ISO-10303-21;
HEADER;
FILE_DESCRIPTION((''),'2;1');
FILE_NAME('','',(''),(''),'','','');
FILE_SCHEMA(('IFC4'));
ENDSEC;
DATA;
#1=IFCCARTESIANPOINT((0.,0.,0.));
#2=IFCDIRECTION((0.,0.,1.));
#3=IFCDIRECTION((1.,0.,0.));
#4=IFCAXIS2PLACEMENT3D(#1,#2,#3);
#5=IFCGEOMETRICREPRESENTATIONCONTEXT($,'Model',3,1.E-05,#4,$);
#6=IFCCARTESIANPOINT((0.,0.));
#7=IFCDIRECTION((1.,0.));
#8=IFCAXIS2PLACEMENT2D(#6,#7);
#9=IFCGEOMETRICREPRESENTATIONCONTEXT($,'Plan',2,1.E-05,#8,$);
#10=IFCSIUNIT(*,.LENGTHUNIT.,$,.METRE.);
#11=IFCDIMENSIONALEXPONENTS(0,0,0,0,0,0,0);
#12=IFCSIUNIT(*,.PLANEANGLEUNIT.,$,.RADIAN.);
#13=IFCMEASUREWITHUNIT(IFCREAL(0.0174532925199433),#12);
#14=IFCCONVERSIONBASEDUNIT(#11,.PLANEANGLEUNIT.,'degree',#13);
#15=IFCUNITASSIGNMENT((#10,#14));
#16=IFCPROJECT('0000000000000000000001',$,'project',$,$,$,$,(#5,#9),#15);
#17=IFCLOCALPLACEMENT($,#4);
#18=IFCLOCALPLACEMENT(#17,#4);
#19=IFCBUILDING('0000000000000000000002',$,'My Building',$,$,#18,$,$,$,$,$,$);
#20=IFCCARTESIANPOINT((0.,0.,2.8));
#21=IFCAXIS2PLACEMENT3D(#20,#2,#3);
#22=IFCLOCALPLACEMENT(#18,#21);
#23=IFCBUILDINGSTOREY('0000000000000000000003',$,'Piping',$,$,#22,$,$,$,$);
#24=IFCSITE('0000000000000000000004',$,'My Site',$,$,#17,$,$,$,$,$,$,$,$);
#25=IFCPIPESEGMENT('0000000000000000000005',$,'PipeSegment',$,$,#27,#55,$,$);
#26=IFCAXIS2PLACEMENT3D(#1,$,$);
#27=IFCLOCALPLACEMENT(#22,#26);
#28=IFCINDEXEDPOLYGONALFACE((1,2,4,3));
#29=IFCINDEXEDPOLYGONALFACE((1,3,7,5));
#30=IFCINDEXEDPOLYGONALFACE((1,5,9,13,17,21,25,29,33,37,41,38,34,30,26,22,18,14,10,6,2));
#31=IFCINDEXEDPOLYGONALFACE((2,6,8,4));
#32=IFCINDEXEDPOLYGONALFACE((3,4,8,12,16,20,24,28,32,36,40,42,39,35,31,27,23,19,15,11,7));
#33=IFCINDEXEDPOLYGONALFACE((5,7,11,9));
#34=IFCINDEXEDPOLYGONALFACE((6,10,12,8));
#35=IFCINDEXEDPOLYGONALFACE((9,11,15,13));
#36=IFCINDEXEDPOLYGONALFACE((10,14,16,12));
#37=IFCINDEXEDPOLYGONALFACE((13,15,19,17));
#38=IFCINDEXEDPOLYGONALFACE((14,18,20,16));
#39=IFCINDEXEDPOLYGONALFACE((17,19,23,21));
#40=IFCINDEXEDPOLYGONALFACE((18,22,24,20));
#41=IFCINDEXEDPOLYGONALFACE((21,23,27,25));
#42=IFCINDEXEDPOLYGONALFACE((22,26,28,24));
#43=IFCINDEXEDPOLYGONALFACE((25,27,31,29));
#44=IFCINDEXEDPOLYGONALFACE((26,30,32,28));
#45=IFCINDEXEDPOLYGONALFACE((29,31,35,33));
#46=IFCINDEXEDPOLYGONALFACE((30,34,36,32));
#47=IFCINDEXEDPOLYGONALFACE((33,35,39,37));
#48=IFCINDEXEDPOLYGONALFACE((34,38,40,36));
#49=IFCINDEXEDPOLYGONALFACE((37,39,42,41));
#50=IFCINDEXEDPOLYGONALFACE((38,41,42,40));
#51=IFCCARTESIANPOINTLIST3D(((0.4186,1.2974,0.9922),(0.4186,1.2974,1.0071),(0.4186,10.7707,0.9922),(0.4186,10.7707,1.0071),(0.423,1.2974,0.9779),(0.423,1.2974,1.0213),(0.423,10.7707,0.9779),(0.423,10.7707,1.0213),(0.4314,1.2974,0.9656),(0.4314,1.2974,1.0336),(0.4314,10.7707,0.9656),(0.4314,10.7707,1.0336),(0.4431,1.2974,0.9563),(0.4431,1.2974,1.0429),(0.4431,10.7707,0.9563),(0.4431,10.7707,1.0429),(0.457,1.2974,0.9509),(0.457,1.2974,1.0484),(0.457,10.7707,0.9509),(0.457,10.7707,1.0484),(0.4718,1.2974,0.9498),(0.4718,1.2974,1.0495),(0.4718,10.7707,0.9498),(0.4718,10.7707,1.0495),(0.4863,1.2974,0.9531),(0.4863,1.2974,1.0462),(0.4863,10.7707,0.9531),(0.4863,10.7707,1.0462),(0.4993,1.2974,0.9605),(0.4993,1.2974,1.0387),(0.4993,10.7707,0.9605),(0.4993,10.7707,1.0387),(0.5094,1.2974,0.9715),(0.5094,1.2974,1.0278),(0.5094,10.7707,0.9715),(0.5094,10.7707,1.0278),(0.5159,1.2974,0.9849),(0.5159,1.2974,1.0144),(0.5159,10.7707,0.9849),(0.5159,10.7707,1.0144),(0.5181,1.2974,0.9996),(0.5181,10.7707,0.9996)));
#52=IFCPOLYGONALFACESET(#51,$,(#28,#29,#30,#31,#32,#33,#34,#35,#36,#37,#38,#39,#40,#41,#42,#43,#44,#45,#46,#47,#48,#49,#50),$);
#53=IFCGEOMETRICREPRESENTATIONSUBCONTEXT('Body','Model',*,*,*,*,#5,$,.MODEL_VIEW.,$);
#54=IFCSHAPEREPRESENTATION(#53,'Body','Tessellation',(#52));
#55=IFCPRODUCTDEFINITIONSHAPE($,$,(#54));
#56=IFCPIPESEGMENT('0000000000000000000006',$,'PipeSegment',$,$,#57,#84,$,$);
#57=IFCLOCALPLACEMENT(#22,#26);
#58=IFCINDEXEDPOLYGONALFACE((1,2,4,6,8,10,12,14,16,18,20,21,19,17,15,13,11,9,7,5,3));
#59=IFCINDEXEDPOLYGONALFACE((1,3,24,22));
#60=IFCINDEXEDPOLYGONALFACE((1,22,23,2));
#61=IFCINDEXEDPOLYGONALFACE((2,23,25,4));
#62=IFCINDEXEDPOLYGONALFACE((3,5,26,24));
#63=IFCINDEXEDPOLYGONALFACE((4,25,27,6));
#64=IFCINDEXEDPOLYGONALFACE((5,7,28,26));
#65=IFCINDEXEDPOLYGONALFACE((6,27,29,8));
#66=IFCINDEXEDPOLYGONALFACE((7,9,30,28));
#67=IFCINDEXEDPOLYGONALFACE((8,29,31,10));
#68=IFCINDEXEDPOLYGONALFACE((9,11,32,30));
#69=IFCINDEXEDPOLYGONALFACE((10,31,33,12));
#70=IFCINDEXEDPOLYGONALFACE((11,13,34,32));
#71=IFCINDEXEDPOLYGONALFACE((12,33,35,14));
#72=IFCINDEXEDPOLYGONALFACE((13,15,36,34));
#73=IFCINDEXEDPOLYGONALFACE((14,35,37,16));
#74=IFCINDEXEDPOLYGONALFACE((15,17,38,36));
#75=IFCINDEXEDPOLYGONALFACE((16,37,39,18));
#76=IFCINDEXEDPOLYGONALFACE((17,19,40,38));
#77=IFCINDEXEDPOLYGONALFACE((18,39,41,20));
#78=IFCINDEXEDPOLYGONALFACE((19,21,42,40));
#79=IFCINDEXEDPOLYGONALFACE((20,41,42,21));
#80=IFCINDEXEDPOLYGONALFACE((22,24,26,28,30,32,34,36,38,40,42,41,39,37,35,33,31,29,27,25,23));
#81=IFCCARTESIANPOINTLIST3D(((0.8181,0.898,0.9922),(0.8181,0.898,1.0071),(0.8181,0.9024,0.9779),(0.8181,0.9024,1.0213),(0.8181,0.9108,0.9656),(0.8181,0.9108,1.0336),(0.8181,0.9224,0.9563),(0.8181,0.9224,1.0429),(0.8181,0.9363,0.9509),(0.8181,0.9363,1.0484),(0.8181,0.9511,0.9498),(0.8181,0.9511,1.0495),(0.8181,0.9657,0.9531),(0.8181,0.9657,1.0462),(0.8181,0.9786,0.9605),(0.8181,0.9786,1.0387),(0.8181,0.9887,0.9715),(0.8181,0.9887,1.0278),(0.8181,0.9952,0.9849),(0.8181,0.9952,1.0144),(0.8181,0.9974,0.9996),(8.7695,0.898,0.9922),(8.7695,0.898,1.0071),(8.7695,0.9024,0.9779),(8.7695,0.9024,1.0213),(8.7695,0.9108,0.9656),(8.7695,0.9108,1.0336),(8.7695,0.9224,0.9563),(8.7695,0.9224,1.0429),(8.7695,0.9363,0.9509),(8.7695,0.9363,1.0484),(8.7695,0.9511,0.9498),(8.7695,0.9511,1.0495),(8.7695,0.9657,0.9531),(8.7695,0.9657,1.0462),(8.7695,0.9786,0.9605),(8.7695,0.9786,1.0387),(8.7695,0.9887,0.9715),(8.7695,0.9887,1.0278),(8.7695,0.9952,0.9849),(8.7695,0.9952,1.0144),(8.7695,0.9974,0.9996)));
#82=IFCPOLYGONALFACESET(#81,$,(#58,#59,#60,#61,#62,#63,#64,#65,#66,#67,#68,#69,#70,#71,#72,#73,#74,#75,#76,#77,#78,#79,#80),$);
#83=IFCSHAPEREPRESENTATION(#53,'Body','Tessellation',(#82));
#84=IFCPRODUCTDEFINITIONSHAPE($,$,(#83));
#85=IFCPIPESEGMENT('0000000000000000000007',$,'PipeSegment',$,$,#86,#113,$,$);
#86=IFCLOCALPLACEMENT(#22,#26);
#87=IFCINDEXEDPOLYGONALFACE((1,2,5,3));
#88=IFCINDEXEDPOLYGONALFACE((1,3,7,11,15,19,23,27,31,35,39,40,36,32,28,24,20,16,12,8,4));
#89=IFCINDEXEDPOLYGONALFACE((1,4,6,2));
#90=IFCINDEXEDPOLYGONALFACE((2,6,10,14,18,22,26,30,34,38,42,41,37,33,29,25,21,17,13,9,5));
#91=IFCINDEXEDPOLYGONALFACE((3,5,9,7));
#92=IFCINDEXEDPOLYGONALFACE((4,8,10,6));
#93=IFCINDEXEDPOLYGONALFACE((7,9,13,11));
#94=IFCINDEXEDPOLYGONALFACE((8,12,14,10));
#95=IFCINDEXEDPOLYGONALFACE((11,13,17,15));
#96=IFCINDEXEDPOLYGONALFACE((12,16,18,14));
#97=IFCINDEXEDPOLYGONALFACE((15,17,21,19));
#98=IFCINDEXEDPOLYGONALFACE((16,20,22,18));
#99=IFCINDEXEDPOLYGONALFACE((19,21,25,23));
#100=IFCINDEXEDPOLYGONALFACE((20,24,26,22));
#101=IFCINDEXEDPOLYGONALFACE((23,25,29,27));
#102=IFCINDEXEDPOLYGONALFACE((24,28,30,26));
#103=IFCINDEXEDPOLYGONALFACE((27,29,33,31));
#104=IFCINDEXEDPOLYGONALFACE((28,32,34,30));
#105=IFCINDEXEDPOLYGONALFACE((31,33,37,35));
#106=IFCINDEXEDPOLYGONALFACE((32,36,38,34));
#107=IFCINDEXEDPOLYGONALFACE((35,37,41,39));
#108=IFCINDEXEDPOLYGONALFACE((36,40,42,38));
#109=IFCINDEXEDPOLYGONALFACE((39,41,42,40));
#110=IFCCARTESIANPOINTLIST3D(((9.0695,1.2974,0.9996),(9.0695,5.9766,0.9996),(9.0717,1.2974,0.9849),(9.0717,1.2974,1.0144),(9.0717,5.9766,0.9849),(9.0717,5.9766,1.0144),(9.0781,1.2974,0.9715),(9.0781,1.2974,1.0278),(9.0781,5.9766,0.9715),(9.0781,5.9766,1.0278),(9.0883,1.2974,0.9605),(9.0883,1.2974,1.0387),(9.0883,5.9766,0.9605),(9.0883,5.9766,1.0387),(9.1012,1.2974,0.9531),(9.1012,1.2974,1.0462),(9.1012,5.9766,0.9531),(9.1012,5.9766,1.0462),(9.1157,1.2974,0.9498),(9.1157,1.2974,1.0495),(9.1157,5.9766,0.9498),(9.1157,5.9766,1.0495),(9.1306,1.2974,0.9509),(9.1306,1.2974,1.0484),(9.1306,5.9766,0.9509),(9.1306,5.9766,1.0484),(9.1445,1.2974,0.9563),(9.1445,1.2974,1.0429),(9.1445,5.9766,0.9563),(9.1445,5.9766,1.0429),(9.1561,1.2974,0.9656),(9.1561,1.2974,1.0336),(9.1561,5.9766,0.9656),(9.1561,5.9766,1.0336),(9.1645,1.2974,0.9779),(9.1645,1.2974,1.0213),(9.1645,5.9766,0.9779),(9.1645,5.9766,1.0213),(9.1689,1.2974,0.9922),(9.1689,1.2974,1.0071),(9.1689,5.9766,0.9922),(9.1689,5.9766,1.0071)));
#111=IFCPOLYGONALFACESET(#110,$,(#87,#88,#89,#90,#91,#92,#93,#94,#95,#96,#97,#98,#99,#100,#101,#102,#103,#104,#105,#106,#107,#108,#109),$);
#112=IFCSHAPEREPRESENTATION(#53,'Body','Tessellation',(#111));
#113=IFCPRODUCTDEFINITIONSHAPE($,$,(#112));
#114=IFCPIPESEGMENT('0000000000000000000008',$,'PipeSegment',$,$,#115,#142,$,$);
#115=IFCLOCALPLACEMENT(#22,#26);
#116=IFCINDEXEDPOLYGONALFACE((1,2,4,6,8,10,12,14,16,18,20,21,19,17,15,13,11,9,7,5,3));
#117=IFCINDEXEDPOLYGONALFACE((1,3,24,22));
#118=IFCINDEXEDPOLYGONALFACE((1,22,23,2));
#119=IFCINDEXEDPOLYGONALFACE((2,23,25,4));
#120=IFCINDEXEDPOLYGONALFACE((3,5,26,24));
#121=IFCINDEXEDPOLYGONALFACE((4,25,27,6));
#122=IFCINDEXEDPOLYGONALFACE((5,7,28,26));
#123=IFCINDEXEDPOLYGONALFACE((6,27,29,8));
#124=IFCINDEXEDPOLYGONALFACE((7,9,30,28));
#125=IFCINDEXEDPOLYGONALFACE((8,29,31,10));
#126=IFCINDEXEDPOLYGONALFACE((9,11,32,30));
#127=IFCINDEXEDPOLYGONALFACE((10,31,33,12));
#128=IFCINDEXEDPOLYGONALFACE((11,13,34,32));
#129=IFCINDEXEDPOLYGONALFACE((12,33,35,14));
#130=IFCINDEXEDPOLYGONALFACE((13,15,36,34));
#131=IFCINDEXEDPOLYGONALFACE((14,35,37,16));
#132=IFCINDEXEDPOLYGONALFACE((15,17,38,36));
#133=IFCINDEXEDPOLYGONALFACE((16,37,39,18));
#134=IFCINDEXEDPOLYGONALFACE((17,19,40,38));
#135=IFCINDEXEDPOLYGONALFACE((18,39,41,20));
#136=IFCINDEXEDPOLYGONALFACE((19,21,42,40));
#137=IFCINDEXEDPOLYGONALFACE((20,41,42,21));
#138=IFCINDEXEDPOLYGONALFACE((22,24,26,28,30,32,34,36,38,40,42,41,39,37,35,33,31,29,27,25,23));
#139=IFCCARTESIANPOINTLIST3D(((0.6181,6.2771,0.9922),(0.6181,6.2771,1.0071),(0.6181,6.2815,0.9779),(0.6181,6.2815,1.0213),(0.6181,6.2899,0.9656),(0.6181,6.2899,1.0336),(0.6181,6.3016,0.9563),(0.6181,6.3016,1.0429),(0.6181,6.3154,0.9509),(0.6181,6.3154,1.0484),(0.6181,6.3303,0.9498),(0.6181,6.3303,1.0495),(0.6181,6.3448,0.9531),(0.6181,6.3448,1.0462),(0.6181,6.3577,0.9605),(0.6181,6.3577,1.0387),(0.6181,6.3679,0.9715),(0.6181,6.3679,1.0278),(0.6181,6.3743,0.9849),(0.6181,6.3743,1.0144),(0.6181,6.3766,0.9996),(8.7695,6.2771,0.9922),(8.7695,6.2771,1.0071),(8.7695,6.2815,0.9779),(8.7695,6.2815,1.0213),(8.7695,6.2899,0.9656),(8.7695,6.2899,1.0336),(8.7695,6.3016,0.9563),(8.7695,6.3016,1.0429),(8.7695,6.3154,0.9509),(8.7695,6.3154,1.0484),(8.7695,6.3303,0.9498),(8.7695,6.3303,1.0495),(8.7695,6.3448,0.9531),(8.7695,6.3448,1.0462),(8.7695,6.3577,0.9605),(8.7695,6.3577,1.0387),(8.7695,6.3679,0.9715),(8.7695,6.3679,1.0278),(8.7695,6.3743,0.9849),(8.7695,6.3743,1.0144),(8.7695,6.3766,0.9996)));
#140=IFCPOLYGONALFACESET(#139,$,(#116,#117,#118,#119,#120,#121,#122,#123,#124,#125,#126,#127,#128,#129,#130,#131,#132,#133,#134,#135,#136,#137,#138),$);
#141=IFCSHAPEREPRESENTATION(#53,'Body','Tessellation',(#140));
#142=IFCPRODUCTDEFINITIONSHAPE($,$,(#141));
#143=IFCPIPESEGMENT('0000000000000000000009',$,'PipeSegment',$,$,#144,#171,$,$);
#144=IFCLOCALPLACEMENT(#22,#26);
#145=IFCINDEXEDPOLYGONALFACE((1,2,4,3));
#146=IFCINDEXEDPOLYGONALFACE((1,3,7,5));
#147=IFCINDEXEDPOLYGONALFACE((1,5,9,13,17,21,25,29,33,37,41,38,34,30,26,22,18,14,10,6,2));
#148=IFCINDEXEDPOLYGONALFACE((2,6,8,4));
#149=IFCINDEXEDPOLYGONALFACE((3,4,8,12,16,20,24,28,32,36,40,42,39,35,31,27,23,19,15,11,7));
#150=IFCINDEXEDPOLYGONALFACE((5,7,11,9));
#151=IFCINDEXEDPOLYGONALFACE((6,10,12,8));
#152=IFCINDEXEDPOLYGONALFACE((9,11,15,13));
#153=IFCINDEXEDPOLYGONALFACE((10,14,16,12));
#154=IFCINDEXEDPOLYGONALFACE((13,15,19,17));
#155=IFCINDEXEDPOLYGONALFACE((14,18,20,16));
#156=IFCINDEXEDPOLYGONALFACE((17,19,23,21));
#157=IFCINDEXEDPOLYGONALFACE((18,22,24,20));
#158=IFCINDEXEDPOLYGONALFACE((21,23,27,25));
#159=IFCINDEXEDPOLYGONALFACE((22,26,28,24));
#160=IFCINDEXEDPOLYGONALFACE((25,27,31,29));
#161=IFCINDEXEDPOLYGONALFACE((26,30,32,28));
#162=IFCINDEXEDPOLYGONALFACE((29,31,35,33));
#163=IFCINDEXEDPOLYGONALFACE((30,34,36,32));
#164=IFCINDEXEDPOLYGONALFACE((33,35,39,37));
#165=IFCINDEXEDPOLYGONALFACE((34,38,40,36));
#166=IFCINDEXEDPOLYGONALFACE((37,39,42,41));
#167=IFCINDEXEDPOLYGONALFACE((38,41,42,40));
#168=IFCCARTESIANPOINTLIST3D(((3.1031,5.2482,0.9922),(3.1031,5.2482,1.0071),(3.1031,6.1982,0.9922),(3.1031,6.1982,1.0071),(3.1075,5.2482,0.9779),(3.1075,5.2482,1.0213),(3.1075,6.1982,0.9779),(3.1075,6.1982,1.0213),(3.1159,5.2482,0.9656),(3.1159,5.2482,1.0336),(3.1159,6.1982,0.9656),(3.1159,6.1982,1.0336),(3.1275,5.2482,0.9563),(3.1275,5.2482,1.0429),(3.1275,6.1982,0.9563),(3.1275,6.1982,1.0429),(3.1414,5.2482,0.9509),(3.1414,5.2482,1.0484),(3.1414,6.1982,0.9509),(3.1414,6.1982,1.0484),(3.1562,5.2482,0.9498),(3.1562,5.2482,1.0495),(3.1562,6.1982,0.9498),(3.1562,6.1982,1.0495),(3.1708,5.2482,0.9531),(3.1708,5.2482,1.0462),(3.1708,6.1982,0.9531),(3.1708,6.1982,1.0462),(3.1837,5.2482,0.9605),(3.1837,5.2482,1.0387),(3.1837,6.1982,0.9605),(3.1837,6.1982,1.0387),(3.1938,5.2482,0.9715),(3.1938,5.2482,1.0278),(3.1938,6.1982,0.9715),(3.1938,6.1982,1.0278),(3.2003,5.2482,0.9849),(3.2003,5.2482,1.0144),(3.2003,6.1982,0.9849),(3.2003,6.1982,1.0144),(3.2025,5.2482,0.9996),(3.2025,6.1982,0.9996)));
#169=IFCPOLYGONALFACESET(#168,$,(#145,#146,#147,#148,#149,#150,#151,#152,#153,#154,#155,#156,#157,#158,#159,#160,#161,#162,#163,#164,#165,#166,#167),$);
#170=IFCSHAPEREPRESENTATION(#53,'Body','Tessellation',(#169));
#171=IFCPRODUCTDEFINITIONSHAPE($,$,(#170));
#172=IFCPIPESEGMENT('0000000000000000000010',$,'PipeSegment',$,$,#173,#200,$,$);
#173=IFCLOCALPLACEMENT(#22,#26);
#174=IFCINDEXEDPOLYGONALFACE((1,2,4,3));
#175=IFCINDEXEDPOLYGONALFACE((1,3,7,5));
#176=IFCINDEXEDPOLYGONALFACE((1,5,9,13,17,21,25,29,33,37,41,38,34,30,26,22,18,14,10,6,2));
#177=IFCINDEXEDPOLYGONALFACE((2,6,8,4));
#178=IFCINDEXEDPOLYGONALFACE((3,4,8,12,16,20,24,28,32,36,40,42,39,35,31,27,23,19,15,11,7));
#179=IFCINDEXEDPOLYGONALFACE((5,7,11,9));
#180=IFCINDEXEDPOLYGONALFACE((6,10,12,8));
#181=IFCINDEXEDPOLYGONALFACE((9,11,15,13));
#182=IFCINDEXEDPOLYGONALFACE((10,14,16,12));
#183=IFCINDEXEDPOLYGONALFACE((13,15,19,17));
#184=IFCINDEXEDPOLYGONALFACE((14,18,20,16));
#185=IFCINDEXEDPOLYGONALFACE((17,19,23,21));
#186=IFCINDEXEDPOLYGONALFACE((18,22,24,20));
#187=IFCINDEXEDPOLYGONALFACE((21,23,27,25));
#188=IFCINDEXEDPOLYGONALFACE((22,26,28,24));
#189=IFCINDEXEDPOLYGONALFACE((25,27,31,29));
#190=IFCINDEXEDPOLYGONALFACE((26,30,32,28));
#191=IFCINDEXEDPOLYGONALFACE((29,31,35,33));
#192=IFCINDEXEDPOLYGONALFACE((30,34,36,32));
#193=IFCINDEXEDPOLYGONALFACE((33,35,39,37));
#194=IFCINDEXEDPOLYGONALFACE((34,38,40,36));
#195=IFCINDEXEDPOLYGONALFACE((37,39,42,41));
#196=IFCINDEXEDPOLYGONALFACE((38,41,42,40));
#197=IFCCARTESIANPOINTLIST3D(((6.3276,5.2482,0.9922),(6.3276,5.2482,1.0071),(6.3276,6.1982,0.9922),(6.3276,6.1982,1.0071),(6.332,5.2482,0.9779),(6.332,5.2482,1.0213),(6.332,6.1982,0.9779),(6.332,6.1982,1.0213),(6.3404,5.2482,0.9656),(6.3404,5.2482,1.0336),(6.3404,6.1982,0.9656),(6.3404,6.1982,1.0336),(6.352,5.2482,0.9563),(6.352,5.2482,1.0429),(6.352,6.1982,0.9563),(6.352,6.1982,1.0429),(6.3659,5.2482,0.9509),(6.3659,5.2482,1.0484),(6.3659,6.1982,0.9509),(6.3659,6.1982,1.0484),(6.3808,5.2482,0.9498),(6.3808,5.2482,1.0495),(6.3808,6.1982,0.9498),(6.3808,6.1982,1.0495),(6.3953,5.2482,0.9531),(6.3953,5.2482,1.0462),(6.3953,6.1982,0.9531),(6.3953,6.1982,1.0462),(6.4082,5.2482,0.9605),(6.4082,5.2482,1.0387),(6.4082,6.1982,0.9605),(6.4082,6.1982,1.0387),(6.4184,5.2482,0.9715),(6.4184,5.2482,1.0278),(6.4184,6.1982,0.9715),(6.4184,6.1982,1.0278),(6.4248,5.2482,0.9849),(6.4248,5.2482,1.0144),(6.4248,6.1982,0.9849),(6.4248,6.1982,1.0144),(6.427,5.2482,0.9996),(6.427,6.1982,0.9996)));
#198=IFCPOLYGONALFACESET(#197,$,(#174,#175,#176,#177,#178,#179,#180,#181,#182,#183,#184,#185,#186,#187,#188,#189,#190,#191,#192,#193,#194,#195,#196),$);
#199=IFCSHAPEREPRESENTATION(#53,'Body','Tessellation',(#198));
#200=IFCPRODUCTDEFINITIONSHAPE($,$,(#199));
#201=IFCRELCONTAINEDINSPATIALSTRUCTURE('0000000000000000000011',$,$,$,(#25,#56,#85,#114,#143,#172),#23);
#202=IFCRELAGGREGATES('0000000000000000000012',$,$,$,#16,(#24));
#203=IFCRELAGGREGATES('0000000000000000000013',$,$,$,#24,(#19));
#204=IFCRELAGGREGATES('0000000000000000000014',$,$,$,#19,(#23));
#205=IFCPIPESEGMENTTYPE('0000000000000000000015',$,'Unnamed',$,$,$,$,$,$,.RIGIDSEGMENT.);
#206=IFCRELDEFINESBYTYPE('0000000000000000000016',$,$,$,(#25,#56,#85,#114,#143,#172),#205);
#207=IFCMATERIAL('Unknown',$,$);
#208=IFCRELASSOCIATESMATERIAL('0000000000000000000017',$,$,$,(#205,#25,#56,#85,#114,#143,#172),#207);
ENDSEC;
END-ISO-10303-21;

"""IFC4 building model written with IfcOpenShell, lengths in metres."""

from ifc_helpers import new_model, entity, si_unit, converted_unit, frame, origin_with_axes, origin_2d_with_axis, place, context, subcontext, project, spatial, circle, extrude, material, material_profile, profile_set, profile_usage, type_object, element, save


model = new_model("IFC4")

# Units and contexts
model_context = context("Model", 3, precision=1e-05, world=origin_with_axes())
plan_context = context("Plan", 2, precision=1e-05, world=origin_2d_with_axis())
body_context = subcontext(model_context, "Body", "Model", "MODEL_VIEW")
ifc_project = project(units=[si_unit("LENGTHUNIT", "METRE"), converted_unit("PLANEANGLEUNIT", "degree", entity("IfcReal", 0.0174532925199433), si_unit("PLANEANGLEUNIT", "RADIAN"), dimensions=[0, 0, 0, 0, 0, 0, 0])], contexts=[model_context, plan_context])

# Site, building, storey
site_placement = place(None, origin_with_axes())
site = spatial("IfcSite", under=ifc_project, at=site_placement, Name="My Site")
building_placement = place(site_placement, origin_with_axes())
building = spatial("IfcBuilding", under=site, at=building_placement, Name="My Building")
storey_placement = place(building_placement, frame((0.0, 0.0, 2.8), z_axis=(0.0, 0.0, 1.0), x_axis=(1.0, 0.0, 0.0)))
storey = spatial("IfcBuildingStorey", under=building, at=storey_placement, Name="Piping")

# Pipe segments
ifc_material = material(Name="Unknown")
ifc_material_profile_1 = material_profile(ifc_material, circle(Radius=0.05))
ifc_profile_set_1 = profile_set([ifc_material_profile_1])
ifc_profile_usage_1 = profile_usage(ifc_profile_set_1, cardinal=5)
pipe_segment_type = type_object("IfcPipeSegmentType", Name="Unnamed", PredefinedType="RIGIDSEGMENT", material=ifc_profile_set_1)
pipe_segment_1_placement = place(storey_placement, frame((0.4681, 10.7707, 0.9996), z_axis=(0.0, -1.0, 0.0), x_axis=(1.0, 0.0, 0.0)))
element("IfcPipeSegment", 1, at=pipe_segment_1_placement, inside=storey, type_object=pipe_segment_type, material=ifc_profile_usage_1, Name="PipeSegment", context=body_context, shape_type="SweptSolid", body=[
    extrude(circle(Radius=0.05), origin_with_axes(), (0.0, 0.0, 1.0), 9.4733),
])
ifc_profile_usage_2 = profile_usage(ifc_profile_set_1, cardinal=5)
pipe_segment_2_placement = place(storey_placement, frame((0.8181, 0.9474, 0.9996), z_axis=(1.0, 0.0, 0.0), x_axis=(0.0, 1.0, 0.0)))
element("IfcPipeSegment", 2, at=pipe_segment_2_placement, inside=storey, type_object=pipe_segment_type, material=ifc_profile_usage_2, Name="PipeSegment", context=body_context, shape_type="SweptSolid", body=[
    extrude(circle(Radius=0.05), origin_with_axes(), (0.0, 0.0, 1.0), 7.9514),
])
ifc_profile_usage_3 = profile_usage(ifc_profile_set_1, cardinal=5)
pipe_segment_3_placement = place(storey_placement, frame((9.1195, 1.2974, 0.9996), z_axis=(0.0, 1.0, 0.0), x_axis=(-1.0, 0.0, 0.0)))
element("IfcPipeSegment", 3, at=pipe_segment_3_placement, inside=storey, type_object=pipe_segment_type, material=ifc_profile_usage_3, Name="PipeSegment", context=body_context, shape_type="SweptSolid", body=[
    extrude(circle(Radius=0.05), origin_with_axes(), (0.0, 0.0, 1.0), 4.6791),
])
ifc_profile_usage_4 = profile_usage(ifc_profile_set_1, cardinal=5)
pipe_segment_4_placement = place(storey_placement, frame((0.6181, 6.3266, 0.9996), z_axis=(1.0, 0.0, 0.0), x_axis=(0.0, 1.0, 0.0)))
element("IfcPipeSegment", 4, at=pipe_segment_4_placement, inside=storey, type_object=pipe_segment_type, material=ifc_profile_usage_4, Name="PipeSegment", context=body_context, shape_type="SweptSolid", body=[
    extrude(circle(Radius=0.05), origin_with_axes(), (0.0, 0.0, 1.0), 8.1514),
])
ifc_profile_usage_5 = profile_usage(ifc_profile_set_1, cardinal=5)
pipe_segment_5_placement = place(storey_placement, frame((3.1525, 6.1982, 0.9996), z_axis=(0.0, -1.0, 0.0), x_axis=(1.0, 0.0, 0.0)))
element("IfcPipeSegment", 5, at=pipe_segment_5_placement, inside=storey, type_object=pipe_segment_type, material=ifc_profile_usage_5, Name="PipeSegment", context=body_context, shape_type="SweptSolid", body=[
    extrude(circle(Radius=0.05), origin_with_axes(), (0.0, 0.0, 1.0), 0.95),
])
ifc_profile_usage_6 = profile_usage(ifc_profile_set_1, cardinal=5)
pipe_segment_6_placement = place(storey_placement, frame((6.377, 6.1982, 0.9996), z_axis=(0.0, -1.0, 0.0), x_axis=(1.0, 0.0, 0.0)))
element("IfcPipeSegment", 6, at=pipe_segment_6_placement, inside=storey, type_object=pipe_segment_type, material=ifc_profile_usage_6, Name="PipeSegment", context=body_context, shape_type="SweptSolid", body=[
    extrude(circle(Radius=0.05), origin_with_axes(), (0.0, 0.0, 1.0), 0.95),
])

save(model, "model.ifc")
